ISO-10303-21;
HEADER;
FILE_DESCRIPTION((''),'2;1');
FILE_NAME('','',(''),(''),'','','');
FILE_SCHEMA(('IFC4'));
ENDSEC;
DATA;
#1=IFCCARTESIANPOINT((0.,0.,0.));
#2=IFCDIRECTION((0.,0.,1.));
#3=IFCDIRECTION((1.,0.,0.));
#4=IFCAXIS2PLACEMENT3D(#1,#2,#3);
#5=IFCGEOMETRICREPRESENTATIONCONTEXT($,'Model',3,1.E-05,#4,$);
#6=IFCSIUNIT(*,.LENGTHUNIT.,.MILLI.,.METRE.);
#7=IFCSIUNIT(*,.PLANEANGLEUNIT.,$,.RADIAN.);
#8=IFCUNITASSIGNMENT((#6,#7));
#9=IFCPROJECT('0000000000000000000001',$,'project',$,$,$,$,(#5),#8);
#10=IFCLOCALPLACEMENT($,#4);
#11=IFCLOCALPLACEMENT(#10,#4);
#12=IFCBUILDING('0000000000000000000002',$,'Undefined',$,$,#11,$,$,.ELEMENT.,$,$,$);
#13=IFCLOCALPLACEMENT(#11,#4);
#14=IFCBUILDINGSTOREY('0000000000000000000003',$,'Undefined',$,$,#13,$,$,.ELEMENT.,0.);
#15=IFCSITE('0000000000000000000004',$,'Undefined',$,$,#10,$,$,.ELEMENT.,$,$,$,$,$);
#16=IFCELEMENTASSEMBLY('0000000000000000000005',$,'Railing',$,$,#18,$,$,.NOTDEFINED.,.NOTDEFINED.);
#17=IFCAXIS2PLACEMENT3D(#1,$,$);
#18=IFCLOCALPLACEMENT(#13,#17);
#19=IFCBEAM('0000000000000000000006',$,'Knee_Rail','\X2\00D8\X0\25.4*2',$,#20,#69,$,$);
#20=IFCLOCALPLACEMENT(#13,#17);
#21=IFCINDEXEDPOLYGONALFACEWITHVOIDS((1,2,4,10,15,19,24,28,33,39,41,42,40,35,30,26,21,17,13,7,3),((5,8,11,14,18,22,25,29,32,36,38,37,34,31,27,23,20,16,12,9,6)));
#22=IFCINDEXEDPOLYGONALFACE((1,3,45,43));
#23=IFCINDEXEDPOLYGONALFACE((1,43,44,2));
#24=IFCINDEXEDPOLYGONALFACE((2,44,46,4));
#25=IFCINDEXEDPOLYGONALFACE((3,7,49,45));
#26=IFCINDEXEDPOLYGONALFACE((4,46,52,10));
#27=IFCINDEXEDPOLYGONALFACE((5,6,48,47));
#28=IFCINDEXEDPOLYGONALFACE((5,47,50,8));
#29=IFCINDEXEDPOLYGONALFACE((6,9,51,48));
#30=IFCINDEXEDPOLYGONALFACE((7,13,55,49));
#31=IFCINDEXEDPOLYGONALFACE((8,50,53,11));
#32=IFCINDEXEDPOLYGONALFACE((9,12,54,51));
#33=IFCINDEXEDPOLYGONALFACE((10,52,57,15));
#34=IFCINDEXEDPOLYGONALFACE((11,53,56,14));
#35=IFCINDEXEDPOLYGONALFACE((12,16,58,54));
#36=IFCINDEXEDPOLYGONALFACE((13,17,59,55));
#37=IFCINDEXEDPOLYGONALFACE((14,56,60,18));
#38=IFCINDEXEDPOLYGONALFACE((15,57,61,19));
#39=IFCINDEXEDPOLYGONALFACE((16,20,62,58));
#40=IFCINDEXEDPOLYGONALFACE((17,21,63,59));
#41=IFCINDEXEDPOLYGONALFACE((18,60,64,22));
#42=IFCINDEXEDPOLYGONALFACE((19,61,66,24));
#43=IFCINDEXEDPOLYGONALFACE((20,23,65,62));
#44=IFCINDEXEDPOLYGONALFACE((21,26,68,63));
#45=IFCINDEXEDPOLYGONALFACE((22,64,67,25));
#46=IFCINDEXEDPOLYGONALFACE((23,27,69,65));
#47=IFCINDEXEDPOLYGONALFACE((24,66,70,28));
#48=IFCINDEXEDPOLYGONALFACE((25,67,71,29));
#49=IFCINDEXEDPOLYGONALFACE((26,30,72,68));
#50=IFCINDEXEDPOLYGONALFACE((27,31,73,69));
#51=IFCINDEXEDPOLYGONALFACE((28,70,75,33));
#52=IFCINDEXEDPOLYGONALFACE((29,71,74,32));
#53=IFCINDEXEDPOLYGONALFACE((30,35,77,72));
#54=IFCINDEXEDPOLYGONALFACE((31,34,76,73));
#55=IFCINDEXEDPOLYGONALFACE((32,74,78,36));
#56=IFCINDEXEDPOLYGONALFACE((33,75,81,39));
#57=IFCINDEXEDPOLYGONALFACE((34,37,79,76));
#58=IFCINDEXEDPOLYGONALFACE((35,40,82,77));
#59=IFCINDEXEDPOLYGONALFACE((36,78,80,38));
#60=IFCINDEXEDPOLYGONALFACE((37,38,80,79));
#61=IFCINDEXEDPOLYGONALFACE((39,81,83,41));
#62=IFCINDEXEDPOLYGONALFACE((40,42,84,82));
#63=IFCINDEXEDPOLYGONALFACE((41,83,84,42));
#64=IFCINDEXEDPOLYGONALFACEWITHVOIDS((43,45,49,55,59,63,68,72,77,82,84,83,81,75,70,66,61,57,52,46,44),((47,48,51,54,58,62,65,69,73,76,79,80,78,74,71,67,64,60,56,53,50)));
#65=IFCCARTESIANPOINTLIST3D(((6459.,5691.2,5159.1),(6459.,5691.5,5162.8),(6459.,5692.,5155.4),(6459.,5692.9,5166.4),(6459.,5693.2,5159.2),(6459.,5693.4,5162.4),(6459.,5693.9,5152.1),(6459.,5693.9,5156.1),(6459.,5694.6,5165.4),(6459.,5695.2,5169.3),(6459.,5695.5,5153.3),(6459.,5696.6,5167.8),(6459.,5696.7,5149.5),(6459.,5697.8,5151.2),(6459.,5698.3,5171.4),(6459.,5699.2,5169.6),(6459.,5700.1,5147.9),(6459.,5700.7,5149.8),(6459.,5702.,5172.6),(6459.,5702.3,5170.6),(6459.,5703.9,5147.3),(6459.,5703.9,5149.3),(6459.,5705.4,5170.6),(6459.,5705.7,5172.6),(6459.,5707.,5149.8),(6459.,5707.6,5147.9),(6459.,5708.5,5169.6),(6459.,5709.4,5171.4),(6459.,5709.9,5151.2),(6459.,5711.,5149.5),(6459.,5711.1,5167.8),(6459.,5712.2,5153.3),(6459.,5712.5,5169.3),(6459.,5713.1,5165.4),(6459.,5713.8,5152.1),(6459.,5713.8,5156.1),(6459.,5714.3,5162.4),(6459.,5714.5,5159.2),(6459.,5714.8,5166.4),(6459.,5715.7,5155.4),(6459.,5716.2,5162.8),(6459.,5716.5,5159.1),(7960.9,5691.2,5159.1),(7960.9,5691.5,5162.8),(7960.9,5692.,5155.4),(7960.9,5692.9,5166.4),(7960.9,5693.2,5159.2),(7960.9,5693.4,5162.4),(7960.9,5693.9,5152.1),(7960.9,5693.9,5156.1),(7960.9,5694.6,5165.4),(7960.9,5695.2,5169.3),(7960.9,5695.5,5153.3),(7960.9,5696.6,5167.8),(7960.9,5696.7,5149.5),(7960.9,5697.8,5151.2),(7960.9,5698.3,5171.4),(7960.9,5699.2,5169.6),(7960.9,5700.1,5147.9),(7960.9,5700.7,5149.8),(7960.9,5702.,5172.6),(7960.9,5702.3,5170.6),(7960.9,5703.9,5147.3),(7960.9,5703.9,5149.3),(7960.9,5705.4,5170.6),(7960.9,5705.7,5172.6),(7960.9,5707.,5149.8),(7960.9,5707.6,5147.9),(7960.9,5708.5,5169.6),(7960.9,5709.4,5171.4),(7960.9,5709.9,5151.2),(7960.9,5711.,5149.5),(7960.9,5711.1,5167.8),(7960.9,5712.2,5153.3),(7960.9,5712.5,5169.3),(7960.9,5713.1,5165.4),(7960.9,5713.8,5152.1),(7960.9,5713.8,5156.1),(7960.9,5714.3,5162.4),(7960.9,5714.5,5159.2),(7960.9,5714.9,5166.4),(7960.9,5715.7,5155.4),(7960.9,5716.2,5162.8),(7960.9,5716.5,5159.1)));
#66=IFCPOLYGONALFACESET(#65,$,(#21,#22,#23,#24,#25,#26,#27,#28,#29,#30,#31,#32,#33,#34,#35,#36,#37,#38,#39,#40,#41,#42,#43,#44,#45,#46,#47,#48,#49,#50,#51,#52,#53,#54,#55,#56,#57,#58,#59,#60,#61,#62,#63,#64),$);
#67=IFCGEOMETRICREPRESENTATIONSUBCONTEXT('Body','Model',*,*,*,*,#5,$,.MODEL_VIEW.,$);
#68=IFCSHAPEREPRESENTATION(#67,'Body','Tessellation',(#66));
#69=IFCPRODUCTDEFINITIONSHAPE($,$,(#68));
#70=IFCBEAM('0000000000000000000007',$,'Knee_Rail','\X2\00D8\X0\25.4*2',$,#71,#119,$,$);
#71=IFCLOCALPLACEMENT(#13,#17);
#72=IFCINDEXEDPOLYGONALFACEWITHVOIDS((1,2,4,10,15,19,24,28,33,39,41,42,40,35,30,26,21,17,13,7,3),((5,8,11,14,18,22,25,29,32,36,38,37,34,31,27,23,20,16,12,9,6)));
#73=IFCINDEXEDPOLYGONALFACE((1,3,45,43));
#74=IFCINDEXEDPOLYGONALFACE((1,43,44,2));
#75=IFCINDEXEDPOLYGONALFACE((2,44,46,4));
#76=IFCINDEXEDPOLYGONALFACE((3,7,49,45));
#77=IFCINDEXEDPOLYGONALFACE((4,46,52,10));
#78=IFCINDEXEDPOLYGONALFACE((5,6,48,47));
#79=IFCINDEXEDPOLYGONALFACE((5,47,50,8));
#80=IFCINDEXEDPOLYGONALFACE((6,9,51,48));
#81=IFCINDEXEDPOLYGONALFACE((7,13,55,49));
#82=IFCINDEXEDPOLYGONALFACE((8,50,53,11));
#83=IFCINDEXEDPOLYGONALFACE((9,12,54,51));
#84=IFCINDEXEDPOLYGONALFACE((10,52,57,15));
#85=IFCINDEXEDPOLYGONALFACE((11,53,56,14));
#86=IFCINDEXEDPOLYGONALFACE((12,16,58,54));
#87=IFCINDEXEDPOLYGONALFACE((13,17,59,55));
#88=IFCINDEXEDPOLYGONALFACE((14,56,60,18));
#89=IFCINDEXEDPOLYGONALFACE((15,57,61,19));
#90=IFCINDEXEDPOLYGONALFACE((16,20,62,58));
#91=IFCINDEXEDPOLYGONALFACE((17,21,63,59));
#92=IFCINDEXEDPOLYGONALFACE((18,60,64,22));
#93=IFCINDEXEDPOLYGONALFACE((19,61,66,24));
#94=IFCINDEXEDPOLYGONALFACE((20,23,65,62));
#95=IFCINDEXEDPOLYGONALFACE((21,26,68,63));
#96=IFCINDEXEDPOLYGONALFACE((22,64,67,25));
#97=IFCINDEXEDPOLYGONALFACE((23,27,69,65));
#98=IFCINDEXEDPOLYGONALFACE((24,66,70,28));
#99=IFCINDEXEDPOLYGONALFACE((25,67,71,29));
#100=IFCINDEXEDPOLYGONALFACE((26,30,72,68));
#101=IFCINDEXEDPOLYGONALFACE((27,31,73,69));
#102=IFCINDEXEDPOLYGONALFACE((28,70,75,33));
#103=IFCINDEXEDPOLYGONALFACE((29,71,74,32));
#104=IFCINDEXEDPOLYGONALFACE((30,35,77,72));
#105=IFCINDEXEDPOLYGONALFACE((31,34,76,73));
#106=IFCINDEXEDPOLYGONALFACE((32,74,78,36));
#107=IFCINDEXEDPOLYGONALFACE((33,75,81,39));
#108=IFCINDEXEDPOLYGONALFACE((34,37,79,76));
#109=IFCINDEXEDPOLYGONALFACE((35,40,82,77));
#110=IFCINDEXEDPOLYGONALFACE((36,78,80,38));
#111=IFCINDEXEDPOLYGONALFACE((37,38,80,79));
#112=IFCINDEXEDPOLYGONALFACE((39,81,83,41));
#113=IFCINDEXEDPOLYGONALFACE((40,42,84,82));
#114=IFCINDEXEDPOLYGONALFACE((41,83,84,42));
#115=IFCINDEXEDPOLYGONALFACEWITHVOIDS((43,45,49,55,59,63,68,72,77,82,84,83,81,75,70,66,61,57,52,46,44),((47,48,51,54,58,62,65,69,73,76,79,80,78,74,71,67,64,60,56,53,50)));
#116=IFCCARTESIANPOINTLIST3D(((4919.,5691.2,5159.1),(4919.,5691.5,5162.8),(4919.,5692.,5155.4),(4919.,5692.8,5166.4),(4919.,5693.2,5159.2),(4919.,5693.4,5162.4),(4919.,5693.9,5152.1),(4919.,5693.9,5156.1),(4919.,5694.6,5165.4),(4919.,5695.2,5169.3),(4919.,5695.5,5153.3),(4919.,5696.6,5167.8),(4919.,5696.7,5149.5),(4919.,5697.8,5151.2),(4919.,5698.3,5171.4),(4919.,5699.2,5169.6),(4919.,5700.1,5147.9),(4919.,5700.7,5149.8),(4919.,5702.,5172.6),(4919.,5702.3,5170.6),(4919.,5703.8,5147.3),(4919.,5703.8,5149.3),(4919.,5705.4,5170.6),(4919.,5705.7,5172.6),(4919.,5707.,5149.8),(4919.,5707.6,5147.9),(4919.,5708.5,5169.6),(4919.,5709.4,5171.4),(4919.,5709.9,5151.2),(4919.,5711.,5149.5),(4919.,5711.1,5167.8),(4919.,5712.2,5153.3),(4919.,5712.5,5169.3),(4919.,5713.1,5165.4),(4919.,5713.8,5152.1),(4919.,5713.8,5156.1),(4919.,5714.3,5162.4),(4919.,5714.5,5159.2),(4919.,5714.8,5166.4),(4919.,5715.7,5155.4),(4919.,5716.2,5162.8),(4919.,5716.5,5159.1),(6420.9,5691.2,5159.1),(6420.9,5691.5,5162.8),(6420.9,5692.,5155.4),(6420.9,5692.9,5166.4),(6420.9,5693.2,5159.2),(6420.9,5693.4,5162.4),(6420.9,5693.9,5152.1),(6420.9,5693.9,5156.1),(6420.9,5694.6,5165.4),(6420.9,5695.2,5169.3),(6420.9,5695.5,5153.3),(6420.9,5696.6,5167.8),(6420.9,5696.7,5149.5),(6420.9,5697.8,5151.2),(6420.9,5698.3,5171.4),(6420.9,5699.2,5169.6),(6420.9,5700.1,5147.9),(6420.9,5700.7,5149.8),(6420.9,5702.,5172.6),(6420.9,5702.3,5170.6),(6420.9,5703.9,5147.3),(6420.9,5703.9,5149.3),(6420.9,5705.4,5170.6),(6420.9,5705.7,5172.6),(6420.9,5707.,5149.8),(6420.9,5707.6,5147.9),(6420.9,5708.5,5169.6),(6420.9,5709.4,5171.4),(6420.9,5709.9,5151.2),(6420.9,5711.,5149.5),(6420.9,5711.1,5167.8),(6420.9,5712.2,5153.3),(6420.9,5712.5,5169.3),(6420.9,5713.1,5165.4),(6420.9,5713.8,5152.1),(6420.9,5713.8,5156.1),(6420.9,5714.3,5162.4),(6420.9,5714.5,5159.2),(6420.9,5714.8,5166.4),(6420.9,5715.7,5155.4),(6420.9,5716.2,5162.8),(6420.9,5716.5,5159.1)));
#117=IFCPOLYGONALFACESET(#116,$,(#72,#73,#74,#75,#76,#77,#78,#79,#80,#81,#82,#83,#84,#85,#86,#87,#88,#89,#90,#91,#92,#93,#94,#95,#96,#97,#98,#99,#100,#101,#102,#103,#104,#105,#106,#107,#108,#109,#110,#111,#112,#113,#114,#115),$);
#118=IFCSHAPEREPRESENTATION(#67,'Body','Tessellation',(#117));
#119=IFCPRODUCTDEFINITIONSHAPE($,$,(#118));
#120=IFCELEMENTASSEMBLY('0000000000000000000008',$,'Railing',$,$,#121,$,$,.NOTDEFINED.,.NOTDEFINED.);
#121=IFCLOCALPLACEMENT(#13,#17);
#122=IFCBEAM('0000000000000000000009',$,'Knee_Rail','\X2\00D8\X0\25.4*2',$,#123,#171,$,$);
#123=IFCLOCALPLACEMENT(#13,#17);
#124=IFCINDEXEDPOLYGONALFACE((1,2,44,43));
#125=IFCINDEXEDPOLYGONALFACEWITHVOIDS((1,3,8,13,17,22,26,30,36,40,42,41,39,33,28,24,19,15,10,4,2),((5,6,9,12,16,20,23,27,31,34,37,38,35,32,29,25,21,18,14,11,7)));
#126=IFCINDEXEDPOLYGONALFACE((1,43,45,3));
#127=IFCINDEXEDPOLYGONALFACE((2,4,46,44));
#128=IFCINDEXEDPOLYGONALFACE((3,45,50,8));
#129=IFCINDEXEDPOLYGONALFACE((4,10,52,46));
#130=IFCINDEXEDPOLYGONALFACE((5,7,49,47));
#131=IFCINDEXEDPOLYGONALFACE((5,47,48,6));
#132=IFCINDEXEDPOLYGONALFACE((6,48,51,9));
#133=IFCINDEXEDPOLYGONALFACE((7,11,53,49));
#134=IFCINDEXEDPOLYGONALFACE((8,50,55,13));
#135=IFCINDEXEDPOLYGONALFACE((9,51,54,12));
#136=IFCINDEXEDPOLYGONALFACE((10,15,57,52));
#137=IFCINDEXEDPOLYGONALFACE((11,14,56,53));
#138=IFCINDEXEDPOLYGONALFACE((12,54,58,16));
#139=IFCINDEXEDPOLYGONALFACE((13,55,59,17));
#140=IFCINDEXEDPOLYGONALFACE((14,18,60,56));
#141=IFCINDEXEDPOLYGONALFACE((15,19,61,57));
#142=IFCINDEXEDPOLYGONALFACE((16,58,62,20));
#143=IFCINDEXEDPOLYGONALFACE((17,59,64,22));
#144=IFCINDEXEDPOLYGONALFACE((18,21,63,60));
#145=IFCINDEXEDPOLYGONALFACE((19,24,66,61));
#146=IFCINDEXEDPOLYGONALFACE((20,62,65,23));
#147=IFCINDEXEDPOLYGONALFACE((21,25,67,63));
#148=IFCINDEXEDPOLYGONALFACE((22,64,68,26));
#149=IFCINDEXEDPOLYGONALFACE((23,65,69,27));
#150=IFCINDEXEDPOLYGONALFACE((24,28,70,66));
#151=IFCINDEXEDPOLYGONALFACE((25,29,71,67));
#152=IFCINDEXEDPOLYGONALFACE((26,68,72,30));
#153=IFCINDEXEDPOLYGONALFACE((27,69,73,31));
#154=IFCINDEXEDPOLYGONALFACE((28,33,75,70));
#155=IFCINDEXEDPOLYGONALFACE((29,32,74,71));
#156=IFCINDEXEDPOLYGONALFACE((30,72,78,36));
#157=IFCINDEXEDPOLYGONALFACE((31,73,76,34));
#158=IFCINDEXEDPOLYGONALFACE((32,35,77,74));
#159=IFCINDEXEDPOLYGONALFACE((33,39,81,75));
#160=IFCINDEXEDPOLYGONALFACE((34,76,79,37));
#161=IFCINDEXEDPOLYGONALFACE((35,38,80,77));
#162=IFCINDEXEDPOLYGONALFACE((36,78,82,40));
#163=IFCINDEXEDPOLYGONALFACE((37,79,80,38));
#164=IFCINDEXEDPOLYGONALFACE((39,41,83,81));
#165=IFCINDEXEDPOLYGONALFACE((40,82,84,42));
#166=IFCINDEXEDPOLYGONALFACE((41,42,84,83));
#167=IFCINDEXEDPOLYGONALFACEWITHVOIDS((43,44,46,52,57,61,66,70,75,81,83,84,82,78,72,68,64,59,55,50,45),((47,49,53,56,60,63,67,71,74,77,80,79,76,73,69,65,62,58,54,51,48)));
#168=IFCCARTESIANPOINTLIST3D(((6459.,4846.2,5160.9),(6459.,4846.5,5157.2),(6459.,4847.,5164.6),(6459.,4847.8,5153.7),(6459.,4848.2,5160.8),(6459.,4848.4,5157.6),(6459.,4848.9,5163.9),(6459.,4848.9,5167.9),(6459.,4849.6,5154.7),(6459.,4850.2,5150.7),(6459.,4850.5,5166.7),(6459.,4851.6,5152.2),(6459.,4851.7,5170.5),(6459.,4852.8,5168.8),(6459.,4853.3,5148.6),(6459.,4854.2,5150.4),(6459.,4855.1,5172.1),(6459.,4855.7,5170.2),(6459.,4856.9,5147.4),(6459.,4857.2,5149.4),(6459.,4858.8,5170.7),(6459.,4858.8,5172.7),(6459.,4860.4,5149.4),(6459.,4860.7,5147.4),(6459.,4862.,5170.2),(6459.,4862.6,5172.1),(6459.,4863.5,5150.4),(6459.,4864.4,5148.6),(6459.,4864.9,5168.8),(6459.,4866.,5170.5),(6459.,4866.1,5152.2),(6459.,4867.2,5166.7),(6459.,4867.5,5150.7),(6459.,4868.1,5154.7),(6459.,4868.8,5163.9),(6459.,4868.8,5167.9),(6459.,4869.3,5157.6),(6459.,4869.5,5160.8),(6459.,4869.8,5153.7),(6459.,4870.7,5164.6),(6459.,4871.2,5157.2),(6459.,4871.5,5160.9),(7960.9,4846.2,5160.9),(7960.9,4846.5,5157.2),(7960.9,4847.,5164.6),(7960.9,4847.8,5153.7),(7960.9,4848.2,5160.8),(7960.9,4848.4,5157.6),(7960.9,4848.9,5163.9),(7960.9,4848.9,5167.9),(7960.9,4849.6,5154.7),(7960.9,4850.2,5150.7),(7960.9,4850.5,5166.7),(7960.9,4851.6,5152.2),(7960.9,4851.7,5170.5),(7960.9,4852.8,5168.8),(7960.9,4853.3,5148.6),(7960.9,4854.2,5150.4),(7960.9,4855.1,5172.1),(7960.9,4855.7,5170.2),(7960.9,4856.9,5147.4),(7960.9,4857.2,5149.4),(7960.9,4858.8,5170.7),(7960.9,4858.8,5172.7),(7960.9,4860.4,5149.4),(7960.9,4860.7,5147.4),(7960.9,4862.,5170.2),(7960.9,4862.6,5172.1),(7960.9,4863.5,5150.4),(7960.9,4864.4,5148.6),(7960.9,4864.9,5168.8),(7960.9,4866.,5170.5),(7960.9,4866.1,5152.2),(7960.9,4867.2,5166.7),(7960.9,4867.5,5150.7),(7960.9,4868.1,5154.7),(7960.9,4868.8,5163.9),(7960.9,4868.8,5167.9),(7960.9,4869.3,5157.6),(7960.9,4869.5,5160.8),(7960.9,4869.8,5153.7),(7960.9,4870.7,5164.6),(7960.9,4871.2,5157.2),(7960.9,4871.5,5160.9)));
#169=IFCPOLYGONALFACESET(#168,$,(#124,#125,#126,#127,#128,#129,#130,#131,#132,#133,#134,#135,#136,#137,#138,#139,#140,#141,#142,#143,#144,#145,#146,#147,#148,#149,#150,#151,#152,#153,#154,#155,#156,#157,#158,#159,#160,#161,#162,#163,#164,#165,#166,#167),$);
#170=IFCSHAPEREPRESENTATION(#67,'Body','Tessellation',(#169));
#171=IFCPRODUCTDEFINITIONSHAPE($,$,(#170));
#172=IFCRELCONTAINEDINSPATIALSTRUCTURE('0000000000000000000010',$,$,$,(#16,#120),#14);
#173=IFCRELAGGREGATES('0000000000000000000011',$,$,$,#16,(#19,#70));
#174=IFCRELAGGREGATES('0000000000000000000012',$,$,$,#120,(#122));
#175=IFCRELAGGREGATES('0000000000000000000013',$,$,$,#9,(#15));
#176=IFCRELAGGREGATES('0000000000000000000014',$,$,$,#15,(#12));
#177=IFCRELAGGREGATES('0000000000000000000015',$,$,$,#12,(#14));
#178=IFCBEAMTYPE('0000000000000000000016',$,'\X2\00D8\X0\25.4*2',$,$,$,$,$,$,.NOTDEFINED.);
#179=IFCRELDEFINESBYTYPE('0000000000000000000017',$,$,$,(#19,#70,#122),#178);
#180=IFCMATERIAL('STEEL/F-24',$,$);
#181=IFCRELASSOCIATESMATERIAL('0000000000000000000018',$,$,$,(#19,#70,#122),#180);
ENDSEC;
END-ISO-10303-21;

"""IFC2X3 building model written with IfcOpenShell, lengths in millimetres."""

from ifc_helpers import new_model, si_unit, frame, origin_with_axes, origin_2d_with_axis, place, context, subcontext, project, spatial, hollow_circle, extrude, material, type_object, element, aggregate, save


model = new_model("IFC2X3")

# Units and contexts
model_context = context("Model", 3, precision=1e-05, world=origin_with_axes())
body_context = subcontext(model_context, "Body", "Model", "MODEL_VIEW")
ifc_project = project(units=[si_unit("LENGTHUNIT", "METRE", prefix="MILLI"), si_unit("PLANEANGLEUNIT", "RADIAN")], contexts=[model_context])

# Site, building, storey
site_placement = place(None, origin_with_axes())
site = spatial("IfcSite", under=ifc_project, at=site_placement, Name="Undefined", CompositionType="ELEMENT")
building_placement = place(site_placement, origin_with_axes())
building = spatial("IfcBuilding", under=site, at=building_placement, Name="Undefined", CompositionType="ELEMENT")
storey_placement = place(building_placement, origin_with_axes())
storey = spatial("IfcBuildingStorey", under=building, at=storey_placement, Name="Undefined", CompositionType="ELEMENT", Elevation=0.0)

# Element assemblies, beams
assembly_1_placement = place(storey_placement, origin_with_axes())
assembly_1 = element("IfcElementAssembly", 1, at=assembly_1_placement, inside=storey, Name="Railing", AssemblyPlace="NOTDEFINED", PredefinedType="NOTDEFINED")
ifc_material_1 = material(Name="STEEL/F-24")
beam_type_1 = type_object("IfcBeamType", Name="Ø25.4*2", PredefinedType="NOTDEFINED")
beam_1_placement = place(assembly_1_placement, frame((6459.0, 5703.9, 5160.0), z_axis=(0.000002, -1.0, 0.0), x_axis=(1.0, 0.000002, 0.0)))
beam_1 = element("IfcBeam", 2, at=beam_1_placement, type_object=beam_type_1, material=ifc_material_1, Name="Knee_Rail", Description="Ø25.4*2", context=body_context, shape_type="SweptSolid", body=[
    extrude(hollow_circle(Radius=12.7, WallThickness=2.0, at=origin_2d_with_axis()), frame((1501.9, 0.0, 0.0), z_axis=(-1.0, 0.0, 0.0), x_axis=(0.0, -1.0, 0.0)), (0.0, 0.0, 1.0), 1501.9),
])
beam_2_placement = place(assembly_1_placement, frame((4919.0, 5703.8, 5160.0), z_axis=(0.000002, -1.0, 0.0), x_axis=(1.0, 0.000002, 0.0)))
beam_2 = element("IfcBeam", 3, at=beam_2_placement, type_object=beam_type_1, material=ifc_material_1, Name="Knee_Rail", Description="Ø25.4*2", context=body_context, shape_type="SweptSolid", body=[
    extrude(hollow_circle(Radius=12.7, WallThickness=2.0, at=origin_2d_with_axis()), frame((1501.9, 0.0, 0.0), z_axis=(-1.0, 0.0, 0.0), x_axis=(0.0, -1.0, 0.0)), (0.0, 0.0, 1.0), 1501.9),
])
assembly_2_placement = place(storey_placement, origin_with_axes())
assembly_2 = element("IfcElementAssembly", 4, at=assembly_2_placement, inside=storey, Name="Railing", AssemblyPlace="NOTDEFINED", PredefinedType="NOTDEFINED")
beam_3_placement = place(assembly_2_placement, frame((6459.0, 4858.8, 5160.0), z_axis=(0.0, 1.0, 0.0), x_axis=(1.0, 0.0, 0.0)))
beam_3 = element("IfcBeam", 5, at=beam_3_placement, type_object=beam_type_1, material=ifc_material_1, Name="Knee_Rail", Description="Ø25.4*2", context=body_context, shape_type="SweptSolid", body=[
    extrude(hollow_circle(Radius=12.7, WallThickness=2.0, at=origin_2d_with_axis()), frame((1501.9, 0.0, 0.0), z_axis=(-1.0, 0.0, 0.0), x_axis=(0.0, -1.0, 0.0)), (0.0, 0.0, 1.0), 1501.9),
])

aggregate(assembly_1, [beam_1, beam_2])
aggregate(assembly_2, [beam_3])

save(model, "model.ifc")
